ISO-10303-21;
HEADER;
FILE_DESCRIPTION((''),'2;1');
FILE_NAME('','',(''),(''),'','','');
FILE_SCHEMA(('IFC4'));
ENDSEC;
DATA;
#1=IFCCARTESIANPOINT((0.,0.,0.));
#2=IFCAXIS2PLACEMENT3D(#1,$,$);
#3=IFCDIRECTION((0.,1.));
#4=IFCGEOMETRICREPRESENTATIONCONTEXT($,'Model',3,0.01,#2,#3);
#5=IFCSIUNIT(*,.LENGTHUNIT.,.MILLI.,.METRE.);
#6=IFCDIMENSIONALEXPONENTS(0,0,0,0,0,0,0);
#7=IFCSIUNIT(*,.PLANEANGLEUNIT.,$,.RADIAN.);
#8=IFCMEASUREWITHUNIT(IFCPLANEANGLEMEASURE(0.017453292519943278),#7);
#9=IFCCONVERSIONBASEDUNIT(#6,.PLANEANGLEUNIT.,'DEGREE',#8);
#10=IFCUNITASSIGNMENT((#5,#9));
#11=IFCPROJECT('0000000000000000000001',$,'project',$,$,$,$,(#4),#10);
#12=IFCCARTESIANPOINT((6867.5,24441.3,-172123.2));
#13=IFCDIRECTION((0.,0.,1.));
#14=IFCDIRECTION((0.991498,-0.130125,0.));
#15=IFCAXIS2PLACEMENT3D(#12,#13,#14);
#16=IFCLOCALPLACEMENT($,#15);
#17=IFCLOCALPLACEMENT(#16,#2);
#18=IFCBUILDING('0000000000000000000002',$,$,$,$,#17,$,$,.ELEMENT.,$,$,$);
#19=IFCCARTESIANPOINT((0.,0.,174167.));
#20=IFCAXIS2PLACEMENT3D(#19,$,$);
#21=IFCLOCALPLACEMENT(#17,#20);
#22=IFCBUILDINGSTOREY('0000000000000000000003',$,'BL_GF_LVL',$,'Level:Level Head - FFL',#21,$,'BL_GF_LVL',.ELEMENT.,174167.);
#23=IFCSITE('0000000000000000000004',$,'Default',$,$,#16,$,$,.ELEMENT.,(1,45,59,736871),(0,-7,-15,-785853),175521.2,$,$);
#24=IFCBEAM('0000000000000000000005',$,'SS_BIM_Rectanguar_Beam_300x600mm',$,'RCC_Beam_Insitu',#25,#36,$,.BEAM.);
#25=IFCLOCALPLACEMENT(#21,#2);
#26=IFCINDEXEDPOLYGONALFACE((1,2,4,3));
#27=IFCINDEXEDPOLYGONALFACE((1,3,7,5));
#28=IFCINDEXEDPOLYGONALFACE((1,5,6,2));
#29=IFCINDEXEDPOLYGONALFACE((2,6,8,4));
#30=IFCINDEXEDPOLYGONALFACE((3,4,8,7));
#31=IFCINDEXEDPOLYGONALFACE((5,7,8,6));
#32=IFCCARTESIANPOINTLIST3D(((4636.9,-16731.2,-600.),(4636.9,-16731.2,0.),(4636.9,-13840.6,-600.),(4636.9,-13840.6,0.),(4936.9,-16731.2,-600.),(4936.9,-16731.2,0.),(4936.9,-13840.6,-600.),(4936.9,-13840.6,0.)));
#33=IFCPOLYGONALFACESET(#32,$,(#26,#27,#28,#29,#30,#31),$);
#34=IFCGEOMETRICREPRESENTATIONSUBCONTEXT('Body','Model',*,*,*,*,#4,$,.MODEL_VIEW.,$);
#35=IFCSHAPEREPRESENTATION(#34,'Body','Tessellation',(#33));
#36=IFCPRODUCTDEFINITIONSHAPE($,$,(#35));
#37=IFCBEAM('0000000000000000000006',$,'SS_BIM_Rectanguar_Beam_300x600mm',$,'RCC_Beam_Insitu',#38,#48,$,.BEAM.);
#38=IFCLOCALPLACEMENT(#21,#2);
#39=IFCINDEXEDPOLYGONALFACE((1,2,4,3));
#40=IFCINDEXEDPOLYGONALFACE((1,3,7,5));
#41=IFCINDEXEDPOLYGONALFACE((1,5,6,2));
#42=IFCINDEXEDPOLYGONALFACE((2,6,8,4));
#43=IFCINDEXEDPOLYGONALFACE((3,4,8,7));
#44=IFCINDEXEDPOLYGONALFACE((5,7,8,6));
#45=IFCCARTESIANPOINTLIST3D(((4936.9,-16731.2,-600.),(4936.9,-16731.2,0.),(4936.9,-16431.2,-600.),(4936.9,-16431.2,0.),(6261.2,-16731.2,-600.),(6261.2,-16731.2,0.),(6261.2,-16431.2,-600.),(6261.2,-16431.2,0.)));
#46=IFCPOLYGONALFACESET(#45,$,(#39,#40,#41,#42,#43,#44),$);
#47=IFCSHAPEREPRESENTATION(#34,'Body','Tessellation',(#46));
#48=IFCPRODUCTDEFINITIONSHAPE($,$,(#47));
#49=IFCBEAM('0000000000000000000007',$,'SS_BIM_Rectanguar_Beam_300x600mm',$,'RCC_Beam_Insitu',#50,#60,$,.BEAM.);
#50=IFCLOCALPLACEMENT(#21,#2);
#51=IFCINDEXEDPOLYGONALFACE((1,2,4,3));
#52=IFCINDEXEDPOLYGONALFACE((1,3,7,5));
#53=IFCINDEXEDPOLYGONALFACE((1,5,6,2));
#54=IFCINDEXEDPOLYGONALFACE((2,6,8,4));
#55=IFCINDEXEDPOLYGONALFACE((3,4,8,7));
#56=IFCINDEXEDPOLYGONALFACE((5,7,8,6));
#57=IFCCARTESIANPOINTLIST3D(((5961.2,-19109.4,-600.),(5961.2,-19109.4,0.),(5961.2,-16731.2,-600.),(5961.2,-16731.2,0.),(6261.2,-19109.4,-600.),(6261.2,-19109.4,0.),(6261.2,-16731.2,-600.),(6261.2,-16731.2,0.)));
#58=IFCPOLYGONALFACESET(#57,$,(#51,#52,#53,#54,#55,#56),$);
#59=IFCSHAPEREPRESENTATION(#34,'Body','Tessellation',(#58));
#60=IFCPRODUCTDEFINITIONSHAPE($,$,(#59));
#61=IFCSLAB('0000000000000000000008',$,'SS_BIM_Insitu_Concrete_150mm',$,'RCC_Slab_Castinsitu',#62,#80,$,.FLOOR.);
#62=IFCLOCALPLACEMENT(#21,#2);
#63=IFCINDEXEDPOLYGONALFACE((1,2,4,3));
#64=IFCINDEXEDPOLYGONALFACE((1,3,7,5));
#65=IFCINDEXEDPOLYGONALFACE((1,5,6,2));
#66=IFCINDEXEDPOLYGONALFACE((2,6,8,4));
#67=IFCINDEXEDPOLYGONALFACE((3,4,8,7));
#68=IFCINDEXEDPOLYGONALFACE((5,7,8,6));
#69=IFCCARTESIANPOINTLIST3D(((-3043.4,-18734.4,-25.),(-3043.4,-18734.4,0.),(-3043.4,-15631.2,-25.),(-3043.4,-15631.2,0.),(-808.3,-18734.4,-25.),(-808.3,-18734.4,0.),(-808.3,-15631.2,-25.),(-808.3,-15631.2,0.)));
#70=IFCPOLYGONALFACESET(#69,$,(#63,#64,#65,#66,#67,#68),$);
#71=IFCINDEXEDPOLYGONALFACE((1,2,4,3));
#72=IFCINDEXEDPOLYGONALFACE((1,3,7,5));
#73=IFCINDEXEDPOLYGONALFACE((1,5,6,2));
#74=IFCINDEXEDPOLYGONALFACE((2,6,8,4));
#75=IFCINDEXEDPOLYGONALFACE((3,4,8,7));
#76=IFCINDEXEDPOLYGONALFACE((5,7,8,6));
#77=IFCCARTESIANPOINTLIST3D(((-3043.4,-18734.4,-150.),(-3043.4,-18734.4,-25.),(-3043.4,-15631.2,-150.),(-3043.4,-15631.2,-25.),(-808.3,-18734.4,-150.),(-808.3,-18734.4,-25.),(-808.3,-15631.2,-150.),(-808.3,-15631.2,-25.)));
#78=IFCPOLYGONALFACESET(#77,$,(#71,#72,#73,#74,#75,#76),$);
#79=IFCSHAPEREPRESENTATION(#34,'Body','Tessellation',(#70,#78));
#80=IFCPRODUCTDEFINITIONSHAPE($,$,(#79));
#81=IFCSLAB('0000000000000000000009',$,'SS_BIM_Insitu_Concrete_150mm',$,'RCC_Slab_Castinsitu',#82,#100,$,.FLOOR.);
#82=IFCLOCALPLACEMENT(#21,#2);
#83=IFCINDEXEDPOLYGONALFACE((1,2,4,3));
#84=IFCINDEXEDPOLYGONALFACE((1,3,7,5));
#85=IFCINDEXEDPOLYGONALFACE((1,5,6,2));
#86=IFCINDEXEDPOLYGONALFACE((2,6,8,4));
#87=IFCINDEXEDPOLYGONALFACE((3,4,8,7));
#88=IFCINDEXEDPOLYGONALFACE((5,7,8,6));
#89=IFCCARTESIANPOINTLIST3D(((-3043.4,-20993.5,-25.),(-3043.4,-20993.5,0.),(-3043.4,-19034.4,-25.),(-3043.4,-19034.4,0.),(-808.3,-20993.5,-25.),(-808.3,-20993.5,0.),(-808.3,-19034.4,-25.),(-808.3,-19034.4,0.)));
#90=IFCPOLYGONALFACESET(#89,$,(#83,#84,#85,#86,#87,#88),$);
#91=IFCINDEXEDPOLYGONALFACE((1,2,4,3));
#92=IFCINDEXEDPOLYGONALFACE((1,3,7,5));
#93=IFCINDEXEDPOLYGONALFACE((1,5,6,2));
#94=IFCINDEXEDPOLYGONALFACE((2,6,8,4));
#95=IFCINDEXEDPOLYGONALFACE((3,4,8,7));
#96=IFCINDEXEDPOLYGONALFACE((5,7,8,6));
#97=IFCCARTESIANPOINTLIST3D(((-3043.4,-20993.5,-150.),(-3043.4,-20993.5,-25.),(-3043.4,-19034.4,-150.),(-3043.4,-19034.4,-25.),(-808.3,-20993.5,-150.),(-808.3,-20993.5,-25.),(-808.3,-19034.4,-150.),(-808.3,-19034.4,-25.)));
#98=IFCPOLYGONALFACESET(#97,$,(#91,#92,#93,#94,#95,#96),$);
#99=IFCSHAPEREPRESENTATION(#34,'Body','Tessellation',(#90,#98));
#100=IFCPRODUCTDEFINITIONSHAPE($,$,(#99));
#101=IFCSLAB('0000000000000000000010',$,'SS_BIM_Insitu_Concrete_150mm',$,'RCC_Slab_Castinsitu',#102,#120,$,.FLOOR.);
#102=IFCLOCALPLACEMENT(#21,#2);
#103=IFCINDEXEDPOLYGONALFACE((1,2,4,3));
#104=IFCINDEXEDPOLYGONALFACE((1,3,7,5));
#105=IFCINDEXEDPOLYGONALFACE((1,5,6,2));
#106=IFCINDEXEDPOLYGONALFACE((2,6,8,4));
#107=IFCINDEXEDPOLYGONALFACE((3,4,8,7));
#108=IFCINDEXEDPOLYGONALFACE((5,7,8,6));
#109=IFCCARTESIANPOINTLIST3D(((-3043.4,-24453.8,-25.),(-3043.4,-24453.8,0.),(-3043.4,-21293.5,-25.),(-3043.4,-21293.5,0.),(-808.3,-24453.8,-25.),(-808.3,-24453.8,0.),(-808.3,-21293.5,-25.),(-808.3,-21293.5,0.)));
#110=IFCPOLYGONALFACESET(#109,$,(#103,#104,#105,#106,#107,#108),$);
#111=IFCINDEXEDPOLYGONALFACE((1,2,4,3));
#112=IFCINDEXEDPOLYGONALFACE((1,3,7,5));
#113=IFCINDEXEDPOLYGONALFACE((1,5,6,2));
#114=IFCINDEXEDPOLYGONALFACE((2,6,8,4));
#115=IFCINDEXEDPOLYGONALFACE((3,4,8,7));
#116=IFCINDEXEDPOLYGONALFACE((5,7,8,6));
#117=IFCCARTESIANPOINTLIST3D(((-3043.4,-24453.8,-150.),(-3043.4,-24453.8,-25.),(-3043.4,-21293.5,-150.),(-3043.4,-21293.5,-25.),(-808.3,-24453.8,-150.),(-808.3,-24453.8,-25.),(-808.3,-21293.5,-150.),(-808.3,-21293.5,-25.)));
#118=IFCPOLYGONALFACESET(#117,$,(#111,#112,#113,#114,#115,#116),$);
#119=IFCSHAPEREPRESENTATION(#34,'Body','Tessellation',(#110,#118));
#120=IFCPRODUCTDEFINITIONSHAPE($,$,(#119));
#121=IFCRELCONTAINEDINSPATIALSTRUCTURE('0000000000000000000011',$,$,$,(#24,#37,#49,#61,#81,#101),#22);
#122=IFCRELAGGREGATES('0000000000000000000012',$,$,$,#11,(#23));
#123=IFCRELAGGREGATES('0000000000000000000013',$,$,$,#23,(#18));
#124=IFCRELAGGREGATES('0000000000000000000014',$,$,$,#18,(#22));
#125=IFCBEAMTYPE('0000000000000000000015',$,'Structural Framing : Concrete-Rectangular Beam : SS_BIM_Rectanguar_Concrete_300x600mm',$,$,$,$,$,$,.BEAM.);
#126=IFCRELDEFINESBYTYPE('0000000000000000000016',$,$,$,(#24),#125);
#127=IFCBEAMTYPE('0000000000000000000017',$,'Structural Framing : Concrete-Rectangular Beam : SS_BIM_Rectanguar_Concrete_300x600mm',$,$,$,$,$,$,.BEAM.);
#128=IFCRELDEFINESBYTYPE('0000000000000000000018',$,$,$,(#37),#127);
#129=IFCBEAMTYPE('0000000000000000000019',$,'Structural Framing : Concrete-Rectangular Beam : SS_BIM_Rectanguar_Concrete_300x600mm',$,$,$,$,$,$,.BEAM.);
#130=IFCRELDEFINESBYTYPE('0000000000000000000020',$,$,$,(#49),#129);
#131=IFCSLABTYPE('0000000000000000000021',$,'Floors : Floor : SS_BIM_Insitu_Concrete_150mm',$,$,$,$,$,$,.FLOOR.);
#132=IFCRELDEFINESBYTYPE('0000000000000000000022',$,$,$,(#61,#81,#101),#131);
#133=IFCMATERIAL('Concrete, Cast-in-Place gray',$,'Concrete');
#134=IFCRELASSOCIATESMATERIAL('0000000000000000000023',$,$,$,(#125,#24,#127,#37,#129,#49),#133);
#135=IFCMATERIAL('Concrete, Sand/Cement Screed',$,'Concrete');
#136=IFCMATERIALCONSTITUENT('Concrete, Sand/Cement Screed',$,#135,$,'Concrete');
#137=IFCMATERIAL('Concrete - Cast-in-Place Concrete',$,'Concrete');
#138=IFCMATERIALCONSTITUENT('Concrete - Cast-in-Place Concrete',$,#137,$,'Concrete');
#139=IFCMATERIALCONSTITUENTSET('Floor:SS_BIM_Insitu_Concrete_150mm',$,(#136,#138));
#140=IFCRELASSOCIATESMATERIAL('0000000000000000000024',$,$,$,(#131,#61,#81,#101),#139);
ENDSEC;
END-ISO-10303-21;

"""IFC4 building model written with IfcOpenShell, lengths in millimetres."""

from ifc_helpers import new_model, entity, si_unit, converted_unit, direction, frame, origin, place, context, subcontext, project, spatial, indexed_curve, outline, extrude, source, transform, mapped, material, constituent, constituent_set, type_object, type_shapes, element, save


model = new_model("IFC4")

# Units and contexts
model_context = context("Model", 3, precision=0.01, world=origin(), true_north=direction((0.0, 1.0)))
body_context = subcontext(model_context, "Body", "Model", "MODEL_VIEW")
ifc_project = project(units=[si_unit("LENGTHUNIT", "METRE", prefix="MILLI"), converted_unit("PLANEANGLEUNIT", "DEGREE", entity("IfcPlaneAngleMeasure", 0.017453292519943278), si_unit("PLANEANGLEUNIT", "RADIAN"), dimensions=[0, 0, 0, 0, 0, 0, 0])], contexts=[model_context])

# Site, building, storey
site_placement = place(None, frame((6867.5, 24441.3, -172123.2), z_axis=(0.0, 0.0, 1.0), x_axis=(0.991498, -0.130125, 0.0)))
site = spatial("IfcSite", under=ifc_project, at=site_placement, Name="Default", CompositionType="ELEMENT", RefLatitude=(1, 45, 59, 736871), RefLongitude=(0, -7, -15, -785853), RefElevation=175521.2)
building_placement = place(site_placement, origin())
building = spatial("IfcBuilding", under=site, at=building_placement, CompositionType="ELEMENT")
storey_placement = place(building_placement, frame((0.0, 0.0, 174167.0)))
storey = spatial("IfcBuildingStorey", under=building, at=storey_placement, Name="BL_GF_LVL", ObjectType="Level:Level Head - FFL", LongName="BL_GF_LVL", CompositionType="ELEMENT", Elevation=174167.0)

# Shared definitions
ifc_material_1 = material(Name="Concrete, Cast-in-Place gray", Category="Concrete")

# Beams
beam_type_1 = type_object("IfcBeamType", Name="Structural Framing : Concrete-Rectangular Beam : SS_BIM_Rectanguar_Concrete_300x600mm", PredefinedType="BEAM", material=ifc_material_1)
shared_shape_1 = source(origin(), body_context, "Body", "SweptSolid", [
    extrude(outline(indexed_curve([(-150.0, -300.0), (150.0, -300.0), (150.0, 300.0), (-150.0, 300.0), (-150.0, -300.0)], self_intersect=False)), frame((4786.9, -13840.6, 173867.0), z_axis=(0.0, -1.0, 0.0), x_axis=(-1.0, 0.0, 0.0)), (0.0, 0.0, 1.0), 2890.6),
])
type_shapes(beam_type_1, [shared_shape_1])
beam_1_placement = place(storey_placement, frame((0.0, 0.0, -174167.0)))
element("IfcBeam", 1, at=beam_1_placement, inside=storey, type_object=beam_type_1, material=ifc_material_1, Name="SS_BIM_Rectanguar_Beam_300x600mm", ObjectType="RCC_Beam_Insitu", PredefinedType="BEAM", context=body_context, shape_type="MappedRepresentation", body=[
    mapped(shared_shape_1, transform((0.0, 0.0, 0.0), scale=1.0)),
])
beam_type_2 = type_object("IfcBeamType", Name="Structural Framing : Concrete-Rectangular Beam : SS_BIM_Rectanguar_Concrete_300x600mm", PredefinedType="BEAM", material=ifc_material_1)
shared_shape_2 = source(origin(), body_context, "Body", "SweptSolid", [
    extrude(outline(indexed_curve([(-300.0, -150.0), (300.0, -150.0), (300.0, 150.0), (-300.0, 150.0), (-300.0, -150.0)], self_intersect=False)), frame((6261.2, -16581.2, 173867.0), z_axis=(-1.0, 0.0, 0.0), x_axis=(0.0, 0.0, -1.0)), (0.0, 0.0, 1.0), 1324.3),
])
type_shapes(beam_type_2, [shared_shape_2])
beam_2_placement = place(storey_placement, frame((0.0, 0.0, -174167.0)))
element("IfcBeam", 2, at=beam_2_placement, inside=storey, type_object=beam_type_2, material=ifc_material_1, Name="SS_BIM_Rectanguar_Beam_300x600mm", ObjectType="RCC_Beam_Insitu", PredefinedType="BEAM", context=body_context, shape_type="MappedRepresentation", body=[
    mapped(shared_shape_2, transform((0.0, 0.0, 0.0), scale=1.0)),
])
beam_type_3 = type_object("IfcBeamType", Name="Structural Framing : Concrete-Rectangular Beam : SS_BIM_Rectanguar_Concrete_300x600mm", PredefinedType="BEAM", material=ifc_material_1)
shared_shape_3 = source(origin(), body_context, "Body", "SweptSolid", [
    extrude(outline(indexed_curve([(-150.0, -300.0), (150.0, -300.0), (150.0, 300.0), (-150.0, 300.0), (-150.0, -300.0)], self_intersect=False)), frame((6111.2, -16731.2, 173867.0), z_axis=(0.0, -1.0, 0.0), x_axis=(-1.0, 0.0, 0.0)), (0.0, 0.0, 1.0), 2378.2),
])
type_shapes(beam_type_3, [shared_shape_3])
beam_3_placement = place(storey_placement, frame((0.0, 0.0, -174167.0)))
element("IfcBeam", 3, at=beam_3_placement, inside=storey, type_object=beam_type_3, material=ifc_material_1, Name="SS_BIM_Rectanguar_Beam_300x600mm", ObjectType="RCC_Beam_Insitu", PredefinedType="BEAM", context=body_context, shape_type="MappedRepresentation", body=[
    mapped(shared_shape_3, transform((0.0, 0.0, 0.0), scale=1.0)),
])

# Slabs
ifc_material_2 = material(Name="Concrete, Sand/Cement Screed", Category="Concrete")
ifc_constituent_1 = constituent(ifc_material_2, Name="Concrete, Sand/Cement Screed", Category="Concrete")
ifc_material_3 = material(Name="Concrete - Cast-in-Place Concrete", Category="Concrete")
ifc_constituent_2 = constituent(ifc_material_3, Name="Concrete - Cast-in-Place Concrete", Category="Concrete")
ifc_constituent_set = constituent_set(constituents=[ifc_constituent_1, ifc_constituent_2], Name="Floor:SS_BIM_Insitu_Concrete_150mm")
slab_type = type_object("IfcSlabType", Name="Floors : Floor : SS_BIM_Insitu_Concrete_150mm", PredefinedType="FLOOR", material=ifc_constituent_set)
slab_1_placement = place(storey_placement, origin())
element("IfcSlab", 4, at=slab_1_placement, inside=storey, type_object=slab_type, material=ifc_constituent_set, Name="SS_BIM_Insitu_Concrete_150mm", ObjectType="RCC_Slab_Castinsitu", PredefinedType="FLOOR", context=body_context, shape_type="SweptSolid", body=[
    extrude(outline(indexed_curve([(-1117.5, -1551.6), (1117.5, -1551.6), (1117.5, 1551.6), (-1117.5, 1551.6), (-1117.5, -1551.6)], self_intersect=False)), frame((-1925.8, -17182.8, -25.0), z_axis=(0.0, 0.0, 1.0), x_axis=(-1.0, 0.0, 0.0)), (0.0, 0.0, 1.0), 25.0),
    extrude(outline(indexed_curve([(-1117.5, -1551.6), (1117.5, -1551.6), (1117.5, 1551.6), (-1117.5, 1551.6), (-1117.5, -1551.6)], self_intersect=False)), frame((-1925.8, -17182.8, -150.0), z_axis=(0.0, 0.0, 1.0), x_axis=(-1.0, 0.0, 0.0)), (0.0, 0.0, 1.0), 125.0),
])
slab_2_placement = place(storey_placement, origin())
element("IfcSlab", 5, at=slab_2_placement, inside=storey, type_object=slab_type, material=ifc_constituent_set, Name="SS_BIM_Insitu_Concrete_150mm", ObjectType="RCC_Slab_Castinsitu", PredefinedType="FLOOR", context=body_context, shape_type="SweptSolid", body=[
    extrude(outline(indexed_curve([(-1117.5, -979.6), (1117.5, -979.6), (1117.5, 979.6), (-1117.5, 979.6), (-1117.5, -979.6)], self_intersect=False)), frame((-1925.8, -20013.9, -25.0), z_axis=(0.0, 0.0, 1.0), x_axis=(-1.0, 0.0, 0.0)), (0.0, 0.0, 1.0), 25.0),
    extrude(outline(indexed_curve([(-1117.5, -979.6), (1117.5, -979.6), (1117.5, 979.6), (-1117.5, 979.6), (-1117.5, -979.6)], self_intersect=False)), frame((-1925.8, -20013.9, -150.0), z_axis=(0.0, 0.0, 1.0), x_axis=(-1.0, 0.0, 0.0)), (0.0, 0.0, 1.0), 125.0),
])
slab_3_placement = place(storey_placement, origin())
element("IfcSlab", 6, at=slab_3_placement, inside=storey, type_object=slab_type, material=ifc_constituent_set, Name="SS_BIM_Insitu_Concrete_150mm", ObjectType="RCC_Slab_Castinsitu", PredefinedType="FLOOR", context=body_context, shape_type="SweptSolid", body=[
    extrude(outline(indexed_curve([(-1117.5, -1580.2), (1117.5, -1580.2), (1117.5, 1580.2), (-1117.5, 1580.2), (-1117.5, -1580.2)], self_intersect=False)), frame((-1925.8, -22873.6, -25.0), z_axis=(0.0, 0.0, 1.0), x_axis=(-1.0, 0.0, 0.0)), (0.0, 0.0, 1.0), 25.0),
    extrude(outline(indexed_curve([(-1117.5, -1580.2), (1117.5, -1580.2), (1117.5, 1580.2), (-1117.5, 1580.2), (-1117.5, -1580.2)], self_intersect=False)), frame((-1925.8, -22873.6, -150.0), z_axis=(0.0, 0.0, 1.0), x_axis=(-1.0, 0.0, 0.0)), (0.0, 0.0, 1.0), 125.0),
])

save(model, "model.ifc")
